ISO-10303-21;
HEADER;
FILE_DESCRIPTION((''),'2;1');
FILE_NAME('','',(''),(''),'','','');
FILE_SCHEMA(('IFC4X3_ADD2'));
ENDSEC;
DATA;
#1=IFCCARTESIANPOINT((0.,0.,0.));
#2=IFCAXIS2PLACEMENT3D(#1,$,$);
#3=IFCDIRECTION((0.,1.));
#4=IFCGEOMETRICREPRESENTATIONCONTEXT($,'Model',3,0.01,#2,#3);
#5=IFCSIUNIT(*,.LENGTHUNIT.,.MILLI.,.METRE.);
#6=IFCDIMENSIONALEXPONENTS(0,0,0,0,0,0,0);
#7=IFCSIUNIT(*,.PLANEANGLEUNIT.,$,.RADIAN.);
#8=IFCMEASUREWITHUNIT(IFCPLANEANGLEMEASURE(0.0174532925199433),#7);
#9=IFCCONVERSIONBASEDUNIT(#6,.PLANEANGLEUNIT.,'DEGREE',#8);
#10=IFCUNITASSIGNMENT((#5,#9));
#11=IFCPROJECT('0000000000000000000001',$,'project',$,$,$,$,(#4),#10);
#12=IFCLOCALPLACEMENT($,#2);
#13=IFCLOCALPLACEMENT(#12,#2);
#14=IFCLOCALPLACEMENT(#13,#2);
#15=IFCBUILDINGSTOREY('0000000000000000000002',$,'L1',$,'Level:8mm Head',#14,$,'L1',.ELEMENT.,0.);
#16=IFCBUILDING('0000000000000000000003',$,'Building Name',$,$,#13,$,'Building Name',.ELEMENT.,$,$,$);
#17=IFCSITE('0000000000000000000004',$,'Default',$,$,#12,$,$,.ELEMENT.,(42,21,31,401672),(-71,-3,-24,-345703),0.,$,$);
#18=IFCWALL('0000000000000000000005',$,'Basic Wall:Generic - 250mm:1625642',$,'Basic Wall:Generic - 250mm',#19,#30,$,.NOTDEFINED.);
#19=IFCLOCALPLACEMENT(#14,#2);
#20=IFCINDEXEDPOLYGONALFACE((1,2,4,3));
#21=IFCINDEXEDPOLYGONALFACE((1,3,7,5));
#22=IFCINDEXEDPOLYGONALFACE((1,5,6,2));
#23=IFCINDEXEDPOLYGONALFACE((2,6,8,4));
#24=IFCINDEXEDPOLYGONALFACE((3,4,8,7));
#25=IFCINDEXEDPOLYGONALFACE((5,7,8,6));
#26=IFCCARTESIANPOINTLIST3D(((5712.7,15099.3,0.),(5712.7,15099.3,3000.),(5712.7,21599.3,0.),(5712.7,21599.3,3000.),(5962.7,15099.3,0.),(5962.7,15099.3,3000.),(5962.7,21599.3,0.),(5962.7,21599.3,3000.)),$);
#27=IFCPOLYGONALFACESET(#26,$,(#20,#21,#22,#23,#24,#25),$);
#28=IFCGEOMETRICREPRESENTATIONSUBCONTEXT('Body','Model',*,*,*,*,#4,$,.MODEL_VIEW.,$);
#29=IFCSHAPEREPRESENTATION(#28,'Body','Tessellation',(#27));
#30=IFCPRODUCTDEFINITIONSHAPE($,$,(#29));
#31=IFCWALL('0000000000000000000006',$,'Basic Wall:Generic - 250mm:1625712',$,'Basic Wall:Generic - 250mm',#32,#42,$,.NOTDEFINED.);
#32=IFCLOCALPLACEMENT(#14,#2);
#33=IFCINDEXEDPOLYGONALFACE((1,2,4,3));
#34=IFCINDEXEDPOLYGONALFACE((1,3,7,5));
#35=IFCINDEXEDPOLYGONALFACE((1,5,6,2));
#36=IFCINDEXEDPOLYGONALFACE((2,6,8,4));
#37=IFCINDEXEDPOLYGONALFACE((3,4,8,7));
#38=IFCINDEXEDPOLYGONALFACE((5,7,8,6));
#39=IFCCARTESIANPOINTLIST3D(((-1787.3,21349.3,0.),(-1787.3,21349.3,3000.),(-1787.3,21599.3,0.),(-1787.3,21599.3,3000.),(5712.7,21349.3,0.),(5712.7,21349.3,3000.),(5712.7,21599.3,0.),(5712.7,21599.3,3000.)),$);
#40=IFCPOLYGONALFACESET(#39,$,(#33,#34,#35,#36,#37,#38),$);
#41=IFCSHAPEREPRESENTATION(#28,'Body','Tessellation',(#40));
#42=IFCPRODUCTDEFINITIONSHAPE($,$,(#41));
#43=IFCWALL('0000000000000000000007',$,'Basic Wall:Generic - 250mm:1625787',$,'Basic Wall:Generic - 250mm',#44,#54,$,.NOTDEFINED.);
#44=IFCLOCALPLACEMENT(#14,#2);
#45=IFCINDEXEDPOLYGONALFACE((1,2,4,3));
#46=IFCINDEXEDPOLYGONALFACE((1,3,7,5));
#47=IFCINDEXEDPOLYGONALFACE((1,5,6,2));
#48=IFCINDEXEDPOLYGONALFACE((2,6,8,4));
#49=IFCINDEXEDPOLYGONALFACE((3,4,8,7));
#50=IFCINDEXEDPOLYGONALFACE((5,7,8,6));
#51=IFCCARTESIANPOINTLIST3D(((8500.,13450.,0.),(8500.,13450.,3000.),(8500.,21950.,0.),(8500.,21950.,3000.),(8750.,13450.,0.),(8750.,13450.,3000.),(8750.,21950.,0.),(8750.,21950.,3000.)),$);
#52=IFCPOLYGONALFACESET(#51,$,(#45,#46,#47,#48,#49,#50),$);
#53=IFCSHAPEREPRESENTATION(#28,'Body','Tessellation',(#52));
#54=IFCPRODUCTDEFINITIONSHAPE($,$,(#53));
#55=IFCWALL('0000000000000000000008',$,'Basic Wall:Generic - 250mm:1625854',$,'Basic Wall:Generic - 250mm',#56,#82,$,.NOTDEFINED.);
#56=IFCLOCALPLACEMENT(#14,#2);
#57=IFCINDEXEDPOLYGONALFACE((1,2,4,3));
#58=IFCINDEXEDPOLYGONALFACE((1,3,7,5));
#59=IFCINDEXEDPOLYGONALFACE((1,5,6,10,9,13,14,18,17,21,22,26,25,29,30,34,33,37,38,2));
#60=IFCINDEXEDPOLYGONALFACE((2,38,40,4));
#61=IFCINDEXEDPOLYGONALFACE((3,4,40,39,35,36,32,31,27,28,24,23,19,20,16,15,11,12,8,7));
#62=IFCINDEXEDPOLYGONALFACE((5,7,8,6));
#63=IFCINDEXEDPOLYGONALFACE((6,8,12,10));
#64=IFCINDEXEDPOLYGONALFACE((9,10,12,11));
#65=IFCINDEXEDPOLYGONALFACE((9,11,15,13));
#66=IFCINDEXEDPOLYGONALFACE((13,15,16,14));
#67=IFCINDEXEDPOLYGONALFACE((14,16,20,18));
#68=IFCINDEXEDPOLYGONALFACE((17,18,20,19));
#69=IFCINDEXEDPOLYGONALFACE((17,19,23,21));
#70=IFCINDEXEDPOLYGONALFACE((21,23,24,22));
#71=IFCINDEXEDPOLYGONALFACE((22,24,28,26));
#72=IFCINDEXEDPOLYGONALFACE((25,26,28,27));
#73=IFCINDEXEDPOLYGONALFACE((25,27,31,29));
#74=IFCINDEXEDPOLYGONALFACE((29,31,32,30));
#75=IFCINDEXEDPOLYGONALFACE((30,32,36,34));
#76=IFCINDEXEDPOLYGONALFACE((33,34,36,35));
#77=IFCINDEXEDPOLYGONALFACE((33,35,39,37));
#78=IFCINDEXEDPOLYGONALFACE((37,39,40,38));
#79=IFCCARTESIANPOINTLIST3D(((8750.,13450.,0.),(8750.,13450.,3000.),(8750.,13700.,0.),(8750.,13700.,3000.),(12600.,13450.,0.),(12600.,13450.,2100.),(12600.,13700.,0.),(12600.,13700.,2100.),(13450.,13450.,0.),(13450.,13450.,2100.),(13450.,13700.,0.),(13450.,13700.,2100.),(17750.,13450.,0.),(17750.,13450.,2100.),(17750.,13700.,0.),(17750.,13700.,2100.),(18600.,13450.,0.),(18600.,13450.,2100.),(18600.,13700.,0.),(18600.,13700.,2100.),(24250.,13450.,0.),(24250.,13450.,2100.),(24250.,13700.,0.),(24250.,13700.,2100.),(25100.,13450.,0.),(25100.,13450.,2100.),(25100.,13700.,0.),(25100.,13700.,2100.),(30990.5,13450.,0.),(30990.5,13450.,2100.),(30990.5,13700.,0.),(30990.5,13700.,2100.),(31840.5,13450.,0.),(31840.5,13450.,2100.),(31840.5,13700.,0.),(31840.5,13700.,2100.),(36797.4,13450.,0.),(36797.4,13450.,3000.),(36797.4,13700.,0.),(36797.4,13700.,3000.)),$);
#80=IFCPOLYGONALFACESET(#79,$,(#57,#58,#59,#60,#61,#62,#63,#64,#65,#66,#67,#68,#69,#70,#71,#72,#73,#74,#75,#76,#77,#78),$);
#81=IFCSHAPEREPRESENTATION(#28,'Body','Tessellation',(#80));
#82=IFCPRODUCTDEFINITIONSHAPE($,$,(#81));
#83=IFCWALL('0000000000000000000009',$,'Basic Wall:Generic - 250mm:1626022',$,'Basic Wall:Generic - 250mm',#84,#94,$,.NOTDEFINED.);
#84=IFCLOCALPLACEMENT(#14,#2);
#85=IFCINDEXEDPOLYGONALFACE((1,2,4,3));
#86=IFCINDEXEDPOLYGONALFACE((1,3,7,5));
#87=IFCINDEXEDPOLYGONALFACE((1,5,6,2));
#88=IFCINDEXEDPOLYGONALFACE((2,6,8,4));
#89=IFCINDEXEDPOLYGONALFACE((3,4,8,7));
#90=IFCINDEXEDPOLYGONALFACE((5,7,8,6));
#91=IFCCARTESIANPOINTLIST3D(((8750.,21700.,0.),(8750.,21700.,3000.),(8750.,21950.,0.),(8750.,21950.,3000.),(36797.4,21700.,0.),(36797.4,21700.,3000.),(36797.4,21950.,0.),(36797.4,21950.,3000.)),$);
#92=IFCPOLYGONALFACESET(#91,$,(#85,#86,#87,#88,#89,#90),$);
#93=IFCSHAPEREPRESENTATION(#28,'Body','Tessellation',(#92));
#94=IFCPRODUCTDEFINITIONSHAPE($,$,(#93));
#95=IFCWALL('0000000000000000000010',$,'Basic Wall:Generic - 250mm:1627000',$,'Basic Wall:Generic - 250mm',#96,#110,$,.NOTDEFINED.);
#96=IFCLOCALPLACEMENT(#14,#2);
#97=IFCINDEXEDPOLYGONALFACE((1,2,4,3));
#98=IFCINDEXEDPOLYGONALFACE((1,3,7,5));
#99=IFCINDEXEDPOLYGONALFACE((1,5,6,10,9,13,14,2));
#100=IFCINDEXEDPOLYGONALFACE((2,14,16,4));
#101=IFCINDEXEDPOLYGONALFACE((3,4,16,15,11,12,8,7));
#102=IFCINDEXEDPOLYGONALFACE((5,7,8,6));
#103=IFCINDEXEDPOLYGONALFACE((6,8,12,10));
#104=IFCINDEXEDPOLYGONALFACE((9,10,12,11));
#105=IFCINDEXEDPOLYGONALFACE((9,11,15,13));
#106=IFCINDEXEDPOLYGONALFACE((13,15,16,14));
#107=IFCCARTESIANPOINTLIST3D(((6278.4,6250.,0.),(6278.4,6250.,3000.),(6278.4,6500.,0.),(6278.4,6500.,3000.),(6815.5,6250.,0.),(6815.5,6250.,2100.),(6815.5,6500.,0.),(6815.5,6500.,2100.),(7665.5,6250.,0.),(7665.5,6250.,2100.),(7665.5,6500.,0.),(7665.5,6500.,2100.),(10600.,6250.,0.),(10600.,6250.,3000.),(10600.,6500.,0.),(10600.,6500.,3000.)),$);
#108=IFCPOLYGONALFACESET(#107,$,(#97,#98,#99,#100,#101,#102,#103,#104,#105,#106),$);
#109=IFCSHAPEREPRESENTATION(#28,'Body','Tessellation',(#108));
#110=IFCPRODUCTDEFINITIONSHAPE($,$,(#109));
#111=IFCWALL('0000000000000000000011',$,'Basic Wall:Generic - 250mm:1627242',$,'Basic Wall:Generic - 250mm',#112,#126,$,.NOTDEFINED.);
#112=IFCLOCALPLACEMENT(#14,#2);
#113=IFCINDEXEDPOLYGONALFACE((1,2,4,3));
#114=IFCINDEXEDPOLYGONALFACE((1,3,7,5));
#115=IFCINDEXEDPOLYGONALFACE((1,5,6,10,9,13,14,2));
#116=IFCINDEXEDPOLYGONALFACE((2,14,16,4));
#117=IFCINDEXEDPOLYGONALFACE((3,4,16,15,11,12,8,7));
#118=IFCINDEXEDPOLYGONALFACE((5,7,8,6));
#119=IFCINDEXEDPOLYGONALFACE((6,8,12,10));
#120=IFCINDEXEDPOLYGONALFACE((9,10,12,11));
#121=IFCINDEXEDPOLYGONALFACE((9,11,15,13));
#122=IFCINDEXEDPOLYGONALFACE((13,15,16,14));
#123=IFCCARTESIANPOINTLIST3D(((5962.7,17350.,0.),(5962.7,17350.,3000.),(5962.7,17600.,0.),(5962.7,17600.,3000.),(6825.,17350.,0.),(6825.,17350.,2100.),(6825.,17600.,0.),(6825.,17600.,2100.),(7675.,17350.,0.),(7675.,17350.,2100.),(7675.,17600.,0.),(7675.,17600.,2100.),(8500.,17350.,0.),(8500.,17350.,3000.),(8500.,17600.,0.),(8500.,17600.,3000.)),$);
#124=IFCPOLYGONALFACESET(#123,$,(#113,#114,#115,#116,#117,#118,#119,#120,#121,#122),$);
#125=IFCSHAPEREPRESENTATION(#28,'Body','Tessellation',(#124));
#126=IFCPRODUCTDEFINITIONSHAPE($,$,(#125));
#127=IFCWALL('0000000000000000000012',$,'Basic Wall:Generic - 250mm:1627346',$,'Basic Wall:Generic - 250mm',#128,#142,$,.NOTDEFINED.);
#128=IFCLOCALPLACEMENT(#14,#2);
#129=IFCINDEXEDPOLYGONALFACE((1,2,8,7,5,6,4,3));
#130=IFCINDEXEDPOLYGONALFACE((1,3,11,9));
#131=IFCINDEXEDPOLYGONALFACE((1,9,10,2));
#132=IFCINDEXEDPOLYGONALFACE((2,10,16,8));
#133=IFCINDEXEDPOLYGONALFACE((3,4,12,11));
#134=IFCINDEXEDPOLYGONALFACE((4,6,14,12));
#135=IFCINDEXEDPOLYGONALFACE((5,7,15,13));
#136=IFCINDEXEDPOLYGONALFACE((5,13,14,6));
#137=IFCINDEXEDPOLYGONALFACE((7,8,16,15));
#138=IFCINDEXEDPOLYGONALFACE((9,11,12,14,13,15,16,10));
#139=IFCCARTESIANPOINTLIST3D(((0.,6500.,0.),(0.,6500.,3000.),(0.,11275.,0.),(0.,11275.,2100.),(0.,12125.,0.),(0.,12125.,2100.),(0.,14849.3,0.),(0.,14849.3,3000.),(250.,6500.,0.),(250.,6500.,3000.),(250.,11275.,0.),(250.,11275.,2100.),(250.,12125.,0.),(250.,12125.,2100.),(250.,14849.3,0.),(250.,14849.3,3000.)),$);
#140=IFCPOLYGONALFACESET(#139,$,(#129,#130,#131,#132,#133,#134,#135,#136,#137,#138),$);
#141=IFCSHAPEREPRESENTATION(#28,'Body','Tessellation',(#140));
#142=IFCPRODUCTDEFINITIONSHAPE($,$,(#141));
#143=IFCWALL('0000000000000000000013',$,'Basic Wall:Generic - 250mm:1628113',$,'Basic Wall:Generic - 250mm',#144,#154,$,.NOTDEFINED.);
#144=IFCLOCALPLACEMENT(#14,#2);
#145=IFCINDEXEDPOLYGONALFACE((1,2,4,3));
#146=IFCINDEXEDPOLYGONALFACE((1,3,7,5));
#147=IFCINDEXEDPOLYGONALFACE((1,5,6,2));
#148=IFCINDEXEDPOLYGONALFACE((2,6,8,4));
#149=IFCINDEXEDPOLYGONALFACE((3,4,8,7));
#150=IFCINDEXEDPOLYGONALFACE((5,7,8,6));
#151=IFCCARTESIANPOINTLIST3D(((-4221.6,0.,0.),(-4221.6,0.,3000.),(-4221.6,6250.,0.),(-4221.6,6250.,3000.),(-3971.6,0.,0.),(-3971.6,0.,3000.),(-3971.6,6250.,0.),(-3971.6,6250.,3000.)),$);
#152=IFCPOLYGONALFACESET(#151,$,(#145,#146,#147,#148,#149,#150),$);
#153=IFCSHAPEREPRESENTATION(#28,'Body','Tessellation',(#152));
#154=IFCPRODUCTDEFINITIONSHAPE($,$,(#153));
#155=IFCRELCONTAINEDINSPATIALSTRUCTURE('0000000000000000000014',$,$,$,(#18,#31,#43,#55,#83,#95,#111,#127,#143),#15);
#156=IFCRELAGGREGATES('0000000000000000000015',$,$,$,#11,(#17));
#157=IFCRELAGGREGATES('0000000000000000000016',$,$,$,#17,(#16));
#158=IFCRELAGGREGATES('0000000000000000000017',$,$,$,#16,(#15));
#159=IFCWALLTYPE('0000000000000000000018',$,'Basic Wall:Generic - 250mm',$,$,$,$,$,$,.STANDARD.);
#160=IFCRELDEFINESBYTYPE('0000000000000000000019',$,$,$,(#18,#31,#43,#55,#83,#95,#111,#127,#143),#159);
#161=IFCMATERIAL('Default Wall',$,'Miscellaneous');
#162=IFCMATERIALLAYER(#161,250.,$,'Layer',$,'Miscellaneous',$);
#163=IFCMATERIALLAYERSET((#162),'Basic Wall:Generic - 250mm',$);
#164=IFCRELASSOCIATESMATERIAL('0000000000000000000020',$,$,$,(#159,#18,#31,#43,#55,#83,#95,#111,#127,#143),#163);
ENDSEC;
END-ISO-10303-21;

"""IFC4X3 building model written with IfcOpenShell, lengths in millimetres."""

from ifc_helpers import new_model, entity, si_unit, converted_unit, direction, frame, frame_2d, origin, place, context, subcontext, project, spatial, rectangle, extrude, material, layer, layer_set, type_object, element, save


model = new_model("IFC4X3")

# Units and contexts
model_context = context("Model", 3, precision=0.01, world=origin(), true_north=direction((0.0, 1.0)))
body_context = subcontext(model_context, "Body", "Model", "MODEL_VIEW")
ifc_project = project(units=[si_unit("LENGTHUNIT", "METRE", prefix="MILLI"), converted_unit("PLANEANGLEUNIT", "DEGREE", entity("IfcPlaneAngleMeasure", 0.0174532925199433), si_unit("PLANEANGLEUNIT", "RADIAN"), dimensions=[0, 0, 0, 0, 0, 0, 0])], contexts=[model_context])

# Site, building, storey
site_placement = place(None, origin())
site = spatial("IfcSite", under=ifc_project, at=site_placement, Name="Default", CompositionType="ELEMENT", RefLatitude=(42, 21, 31, 401672), RefLongitude=(-71, -3, -24, -345703), RefElevation=0.0)
building_placement = place(site_placement, origin())
building = spatial("IfcBuilding", under=site, at=building_placement, Name="Building Name", LongName="Building Name", CompositionType="ELEMENT")
storey_placement = place(building_placement, origin())
storey = spatial("IfcBuildingStorey", under=building, at=storey_placement, Name="L1", ObjectType="Level:8mm Head", LongName="L1", CompositionType="ELEMENT", Elevation=0.0)

# Shared definitions
ifc_material = material(Name="Default Wall", Category="Miscellaneous")
ifc_layer = layer(ifc_material, 250.0, Name="Layer", Category="Miscellaneous")
ifc_layer_set = layer_set([ifc_layer], Name="Basic Wall:Generic - 250mm")
wall_type = type_object("IfcWallType", Name="Basic Wall:Generic - 250mm", PredefinedType="STANDARD", material=ifc_layer_set)

# Walls
wall_1_placement = place(storey_placement, frame((5837.7, 15099.3, 0.0), z_axis=(0.0, 0.0, 1.0), x_axis=(0.0, 1.0, 0.0)))
element("IfcWall", 1, at=wall_1_placement, inside=storey, type_object=wall_type, material=ifc_layer_set, Name="Basic Wall:Generic - 250mm:1625642", ObjectType="Basic Wall:Generic - 250mm", PredefinedType="NOTDEFINED", context=body_context, shape_type="SweptSolid", body=[
    extrude(rectangle(XDim=6500.0, YDim=250.0, at=frame_2d((3250.0, 0.0), x_axis=(-1.0, 0.0))), origin(), (0.0, 0.0, 1.0), 3000.0),
])
wall_2_placement = place(storey_placement, frame((5712.7, 21474.3, 0.0), z_axis=(0.0, 0.0, 1.0), x_axis=(-1.0, 0.0, 0.0)))
element("IfcWall", 2, at=wall_2_placement, inside=storey, type_object=wall_type, material=ifc_layer_set, Name="Basic Wall:Generic - 250mm:1625712", ObjectType="Basic Wall:Generic - 250mm", PredefinedType="NOTDEFINED", context=body_context, shape_type="SweptSolid", body=[
    extrude(rectangle(XDim=7500.0, YDim=250.0, at=frame_2d((3750.0, 0.0), x_axis=(-1.0, 0.0))), origin(), (0.0, 0.0, 1.0), 3000.0),
])
wall_3_placement = place(storey_placement, frame((8625.0, 21950.0, 0.0), z_axis=(0.0, 0.0, 1.0), x_axis=(0.0, -1.0, 0.0)))
element("IfcWall", 3, at=wall_3_placement, inside=storey, type_object=wall_type, material=ifc_layer_set, Name="Basic Wall:Generic - 250mm:1625787", ObjectType="Basic Wall:Generic - 250mm", PredefinedType="NOTDEFINED", context=body_context, shape_type="SweptSolid", body=[
    extrude(rectangle(XDim=8500.0, YDim=250.0, at=frame_2d((4250.0, 0.0), x_axis=(-1.0, 0.0))), origin(), (0.0, 0.0, 1.0), 3000.0),
])

# Wall, openings
wall_4_placement = place(storey_placement, frame((8750.0, 13575.0, 0.0)))
wall_4 = element("IfcWall", 4, at=wall_4_placement, inside=storey, type_object=wall_type, material=ifc_layer_set, Name="Basic Wall:Generic - 250mm:1625854", ObjectType="Basic Wall:Generic - 250mm", PredefinedType="NOTDEFINED", context=body_context, shape_type="SweptSolid", body=[
    extrude(rectangle(XDim=28047.4, YDim=250.0, at=frame_2d((14023.7, 0.0), x_axis=(-1.0, 0.0))), origin(), (0.0, 0.0, 1.0), 3000.0),
])
opening_1_placement = place(wall_4_placement, frame((9000.0, -125.0, 0.0)))
element("IfcOpeningElement", 5, at=opening_1_placement, cuts=wall_4, PredefinedType="OPENING", context=body_context, shape_type="SweptSolid", body=[
    extrude(rectangle(XDim=2100.0, YDim=850.0, at=frame_2d((1050.0, 425.0), x_axis=(1.0, 0.0))), frame((0.0, 0.0, 0.0), z_axis=(0.0, 1.0, 0.0), x_axis=(0.0, 0.0, 1.0)), (0.0, 0.0, 1.0), 250.0),
])
opening_2_placement = place(wall_4_placement, frame((3850.0, -125.0, 0.0)))
element("IfcOpeningElement", 6, at=opening_2_placement, cuts=wall_4, PredefinedType="OPENING", context=body_context, shape_type="SweptSolid", body=[
    extrude(rectangle(XDim=2100.0, YDim=850.0, at=frame_2d((1050.0, 425.0), x_axis=(1.0, 0.0))), frame((0.0, 0.0, 0.0), z_axis=(0.0, 1.0, 0.0), x_axis=(0.0, 0.0, 1.0)), (0.0, 0.0, 1.0), 250.0),
])
opening_3_placement = place(wall_4_placement, frame((22240.5, -125.0, 0.0)))
element("IfcOpeningElement", 7, at=opening_3_placement, cuts=wall_4, PredefinedType="OPENING", context=body_context, shape_type="SweptSolid", body=[
    extrude(rectangle(XDim=2100.0, YDim=850.0, at=frame_2d((1050.0, 425.0), x_axis=(1.0, 0.0))), frame((0.0, 0.0, 0.0), z_axis=(0.0, 1.0, 0.0), x_axis=(0.0, 0.0, 1.0)), (0.0, 0.0, 1.0), 250.0),
])
opening_4_placement = place(wall_4_placement, frame((15500.0, -125.0, 0.0)))
element("IfcOpeningElement", 8, at=opening_4_placement, cuts=wall_4, PredefinedType="OPENING", context=body_context, shape_type="SweptSolid", body=[
    extrude(rectangle(XDim=2100.0, YDim=850.0, at=frame_2d((1050.0, 425.0), x_axis=(1.0, 0.0))), frame((0.0, 0.0, 0.0), z_axis=(0.0, 1.0, 0.0), x_axis=(0.0, 0.0, 1.0)), (0.0, 0.0, 1.0), 250.0),
])

# Wall
wall_5_placement = place(storey_placement, frame((36797.4, 21825.0, 0.0), z_axis=(0.0, 0.0, 1.0), x_axis=(-1.0, 0.0, 0.0)))
element("IfcWall", 9, at=wall_5_placement, inside=storey, type_object=wall_type, material=ifc_layer_set, Name="Basic Wall:Generic - 250mm:1626022", ObjectType="Basic Wall:Generic - 250mm", PredefinedType="NOTDEFINED", context=body_context, shape_type="SweptSolid", body=[
    extrude(rectangle(XDim=28047.4, YDim=250.0, at=frame_2d((14023.7, 0.0), x_axis=(-1.0, 0.0))), origin(), (0.0, 0.0, 1.0), 3000.0),
])

# Walls, openings
wall_6_placement = place(storey_placement, frame((10600.0, 6375.0, 0.0), z_axis=(0.0, 0.0, 1.0), x_axis=(-1.0, 0.0, 0.0)))
wall_6 = element("IfcWall", 10, at=wall_6_placement, inside=storey, type_object=wall_type, material=ifc_layer_set, Name="Basic Wall:Generic - 250mm:1627000", ObjectType="Basic Wall:Generic - 250mm", PredefinedType="NOTDEFINED", context=body_context, shape_type="SweptSolid", body=[
    extrude(rectangle(XDim=4321.6, YDim=250.0, at=frame_2d((2160.8, 0.0), x_axis=(-1.0, 0.0))), origin(), (0.0, 0.0, 1.0), 3000.0),
])
opening_5_placement = place(wall_6_placement, frame((3784.5, 125.0, 0.0)))
element("IfcOpeningElement", 11, at=opening_5_placement, cuts=wall_6, PredefinedType="OPENING", context=body_context, shape_type="SweptSolid", body=[
    extrude(rectangle(XDim=2100.0, YDim=850.0, at=frame_2d((1050.0, 425.0), x_axis=(1.0, 0.0))), frame((0.0, 0.0, 0.0), z_axis=(0.0, -1.0, 0.0), x_axis=(0.0, 0.0, 1.0)), (0.0, 0.0, 1.0), 250.0),
])
wall_7_placement = place(storey_placement, frame((5962.7, 17475.0, 0.0)))
wall_7 = element("IfcWall", 12, at=wall_7_placement, inside=storey, type_object=wall_type, material=ifc_layer_set, Name="Basic Wall:Generic - 250mm:1627242", ObjectType="Basic Wall:Generic - 250mm", PredefinedType="NOTDEFINED", context=body_context, shape_type="SweptSolid", body=[
    extrude(rectangle(XDim=2537.3, YDim=250.0, at=frame_2d((1268.6, 0.0), x_axis=(-1.0, 0.0))), origin(), (0.0, 0.0, 1.0), 3000.0),
])
opening_6_placement = place(wall_7_placement, frame((862.3, -125.0, 0.0)))
element("IfcOpeningElement", 13, at=opening_6_placement, cuts=wall_7, PredefinedType="OPENING", context=body_context, shape_type="SweptSolid", body=[
    extrude(rectangle(XDim=2100.0, YDim=850.0, at=frame_2d((1050.0, 425.0), x_axis=(1.0, 0.0))), frame((0.0, 0.0, 0.0), z_axis=(0.0, 1.0, 0.0), x_axis=(0.0, 0.0, 1.0)), (0.0, 0.0, 1.0), 250.0),
])
wall_8_placement = place(storey_placement, frame((125.0, 6500.0, 0.0), z_axis=(0.0, 0.0, 1.0), x_axis=(0.0, 1.0, 0.0)))
wall_8 = element("IfcWall", 14, at=wall_8_placement, inside=storey, type_object=wall_type, material=ifc_layer_set, Name="Basic Wall:Generic - 250mm:1627346", ObjectType="Basic Wall:Generic - 250mm", PredefinedType="NOTDEFINED", context=body_context, shape_type="SweptSolid", body=[
    extrude(rectangle(XDim=8349.3, YDim=250.0, at=frame_2d((4174.6, 0.0), x_axis=(1.0, 0.0))), origin(), (0.0, 0.0, 1.0), 3000.0),
])
opening_7_placement = place(wall_8_placement, frame((5625.0, 125.0, 0.0)))
element("IfcOpeningElement", 15, at=opening_7_placement, cuts=wall_8, PredefinedType="OPENING", context=body_context, shape_type="SweptSolid", body=[
    extrude(rectangle(XDim=2100.0, YDim=850.0, at=frame_2d((1050.0, 425.0), x_axis=(1.0, 0.0))), frame((0.0, 0.0, 0.0), z_axis=(0.0, -1.0, 0.0), x_axis=(0.0, 0.0, 1.0)), (0.0, 0.0, 1.0), 250.0),
])

# Wall
wall_9_placement = place(storey_placement, frame((-4096.6, 6250.0, 0.0), z_axis=(0.0, 0.0, 1.0), x_axis=(0.0, -1.0, 0.0)))
element("IfcWall", 16, at=wall_9_placement, inside=storey, type_object=wall_type, material=ifc_layer_set, Name="Basic Wall:Generic - 250mm:1628113", ObjectType="Basic Wall:Generic - 250mm", PredefinedType="NOTDEFINED", context=body_context, shape_type="SweptSolid", body=[
    extrude(rectangle(XDim=6250.0, YDim=250.0, at=frame_2d((3125.0, 0.0), x_axis=(-1.0, 0.0))), origin(), (0.0, 0.0, 1.0), 3000.0),
])

save(model, "model.ifc")
